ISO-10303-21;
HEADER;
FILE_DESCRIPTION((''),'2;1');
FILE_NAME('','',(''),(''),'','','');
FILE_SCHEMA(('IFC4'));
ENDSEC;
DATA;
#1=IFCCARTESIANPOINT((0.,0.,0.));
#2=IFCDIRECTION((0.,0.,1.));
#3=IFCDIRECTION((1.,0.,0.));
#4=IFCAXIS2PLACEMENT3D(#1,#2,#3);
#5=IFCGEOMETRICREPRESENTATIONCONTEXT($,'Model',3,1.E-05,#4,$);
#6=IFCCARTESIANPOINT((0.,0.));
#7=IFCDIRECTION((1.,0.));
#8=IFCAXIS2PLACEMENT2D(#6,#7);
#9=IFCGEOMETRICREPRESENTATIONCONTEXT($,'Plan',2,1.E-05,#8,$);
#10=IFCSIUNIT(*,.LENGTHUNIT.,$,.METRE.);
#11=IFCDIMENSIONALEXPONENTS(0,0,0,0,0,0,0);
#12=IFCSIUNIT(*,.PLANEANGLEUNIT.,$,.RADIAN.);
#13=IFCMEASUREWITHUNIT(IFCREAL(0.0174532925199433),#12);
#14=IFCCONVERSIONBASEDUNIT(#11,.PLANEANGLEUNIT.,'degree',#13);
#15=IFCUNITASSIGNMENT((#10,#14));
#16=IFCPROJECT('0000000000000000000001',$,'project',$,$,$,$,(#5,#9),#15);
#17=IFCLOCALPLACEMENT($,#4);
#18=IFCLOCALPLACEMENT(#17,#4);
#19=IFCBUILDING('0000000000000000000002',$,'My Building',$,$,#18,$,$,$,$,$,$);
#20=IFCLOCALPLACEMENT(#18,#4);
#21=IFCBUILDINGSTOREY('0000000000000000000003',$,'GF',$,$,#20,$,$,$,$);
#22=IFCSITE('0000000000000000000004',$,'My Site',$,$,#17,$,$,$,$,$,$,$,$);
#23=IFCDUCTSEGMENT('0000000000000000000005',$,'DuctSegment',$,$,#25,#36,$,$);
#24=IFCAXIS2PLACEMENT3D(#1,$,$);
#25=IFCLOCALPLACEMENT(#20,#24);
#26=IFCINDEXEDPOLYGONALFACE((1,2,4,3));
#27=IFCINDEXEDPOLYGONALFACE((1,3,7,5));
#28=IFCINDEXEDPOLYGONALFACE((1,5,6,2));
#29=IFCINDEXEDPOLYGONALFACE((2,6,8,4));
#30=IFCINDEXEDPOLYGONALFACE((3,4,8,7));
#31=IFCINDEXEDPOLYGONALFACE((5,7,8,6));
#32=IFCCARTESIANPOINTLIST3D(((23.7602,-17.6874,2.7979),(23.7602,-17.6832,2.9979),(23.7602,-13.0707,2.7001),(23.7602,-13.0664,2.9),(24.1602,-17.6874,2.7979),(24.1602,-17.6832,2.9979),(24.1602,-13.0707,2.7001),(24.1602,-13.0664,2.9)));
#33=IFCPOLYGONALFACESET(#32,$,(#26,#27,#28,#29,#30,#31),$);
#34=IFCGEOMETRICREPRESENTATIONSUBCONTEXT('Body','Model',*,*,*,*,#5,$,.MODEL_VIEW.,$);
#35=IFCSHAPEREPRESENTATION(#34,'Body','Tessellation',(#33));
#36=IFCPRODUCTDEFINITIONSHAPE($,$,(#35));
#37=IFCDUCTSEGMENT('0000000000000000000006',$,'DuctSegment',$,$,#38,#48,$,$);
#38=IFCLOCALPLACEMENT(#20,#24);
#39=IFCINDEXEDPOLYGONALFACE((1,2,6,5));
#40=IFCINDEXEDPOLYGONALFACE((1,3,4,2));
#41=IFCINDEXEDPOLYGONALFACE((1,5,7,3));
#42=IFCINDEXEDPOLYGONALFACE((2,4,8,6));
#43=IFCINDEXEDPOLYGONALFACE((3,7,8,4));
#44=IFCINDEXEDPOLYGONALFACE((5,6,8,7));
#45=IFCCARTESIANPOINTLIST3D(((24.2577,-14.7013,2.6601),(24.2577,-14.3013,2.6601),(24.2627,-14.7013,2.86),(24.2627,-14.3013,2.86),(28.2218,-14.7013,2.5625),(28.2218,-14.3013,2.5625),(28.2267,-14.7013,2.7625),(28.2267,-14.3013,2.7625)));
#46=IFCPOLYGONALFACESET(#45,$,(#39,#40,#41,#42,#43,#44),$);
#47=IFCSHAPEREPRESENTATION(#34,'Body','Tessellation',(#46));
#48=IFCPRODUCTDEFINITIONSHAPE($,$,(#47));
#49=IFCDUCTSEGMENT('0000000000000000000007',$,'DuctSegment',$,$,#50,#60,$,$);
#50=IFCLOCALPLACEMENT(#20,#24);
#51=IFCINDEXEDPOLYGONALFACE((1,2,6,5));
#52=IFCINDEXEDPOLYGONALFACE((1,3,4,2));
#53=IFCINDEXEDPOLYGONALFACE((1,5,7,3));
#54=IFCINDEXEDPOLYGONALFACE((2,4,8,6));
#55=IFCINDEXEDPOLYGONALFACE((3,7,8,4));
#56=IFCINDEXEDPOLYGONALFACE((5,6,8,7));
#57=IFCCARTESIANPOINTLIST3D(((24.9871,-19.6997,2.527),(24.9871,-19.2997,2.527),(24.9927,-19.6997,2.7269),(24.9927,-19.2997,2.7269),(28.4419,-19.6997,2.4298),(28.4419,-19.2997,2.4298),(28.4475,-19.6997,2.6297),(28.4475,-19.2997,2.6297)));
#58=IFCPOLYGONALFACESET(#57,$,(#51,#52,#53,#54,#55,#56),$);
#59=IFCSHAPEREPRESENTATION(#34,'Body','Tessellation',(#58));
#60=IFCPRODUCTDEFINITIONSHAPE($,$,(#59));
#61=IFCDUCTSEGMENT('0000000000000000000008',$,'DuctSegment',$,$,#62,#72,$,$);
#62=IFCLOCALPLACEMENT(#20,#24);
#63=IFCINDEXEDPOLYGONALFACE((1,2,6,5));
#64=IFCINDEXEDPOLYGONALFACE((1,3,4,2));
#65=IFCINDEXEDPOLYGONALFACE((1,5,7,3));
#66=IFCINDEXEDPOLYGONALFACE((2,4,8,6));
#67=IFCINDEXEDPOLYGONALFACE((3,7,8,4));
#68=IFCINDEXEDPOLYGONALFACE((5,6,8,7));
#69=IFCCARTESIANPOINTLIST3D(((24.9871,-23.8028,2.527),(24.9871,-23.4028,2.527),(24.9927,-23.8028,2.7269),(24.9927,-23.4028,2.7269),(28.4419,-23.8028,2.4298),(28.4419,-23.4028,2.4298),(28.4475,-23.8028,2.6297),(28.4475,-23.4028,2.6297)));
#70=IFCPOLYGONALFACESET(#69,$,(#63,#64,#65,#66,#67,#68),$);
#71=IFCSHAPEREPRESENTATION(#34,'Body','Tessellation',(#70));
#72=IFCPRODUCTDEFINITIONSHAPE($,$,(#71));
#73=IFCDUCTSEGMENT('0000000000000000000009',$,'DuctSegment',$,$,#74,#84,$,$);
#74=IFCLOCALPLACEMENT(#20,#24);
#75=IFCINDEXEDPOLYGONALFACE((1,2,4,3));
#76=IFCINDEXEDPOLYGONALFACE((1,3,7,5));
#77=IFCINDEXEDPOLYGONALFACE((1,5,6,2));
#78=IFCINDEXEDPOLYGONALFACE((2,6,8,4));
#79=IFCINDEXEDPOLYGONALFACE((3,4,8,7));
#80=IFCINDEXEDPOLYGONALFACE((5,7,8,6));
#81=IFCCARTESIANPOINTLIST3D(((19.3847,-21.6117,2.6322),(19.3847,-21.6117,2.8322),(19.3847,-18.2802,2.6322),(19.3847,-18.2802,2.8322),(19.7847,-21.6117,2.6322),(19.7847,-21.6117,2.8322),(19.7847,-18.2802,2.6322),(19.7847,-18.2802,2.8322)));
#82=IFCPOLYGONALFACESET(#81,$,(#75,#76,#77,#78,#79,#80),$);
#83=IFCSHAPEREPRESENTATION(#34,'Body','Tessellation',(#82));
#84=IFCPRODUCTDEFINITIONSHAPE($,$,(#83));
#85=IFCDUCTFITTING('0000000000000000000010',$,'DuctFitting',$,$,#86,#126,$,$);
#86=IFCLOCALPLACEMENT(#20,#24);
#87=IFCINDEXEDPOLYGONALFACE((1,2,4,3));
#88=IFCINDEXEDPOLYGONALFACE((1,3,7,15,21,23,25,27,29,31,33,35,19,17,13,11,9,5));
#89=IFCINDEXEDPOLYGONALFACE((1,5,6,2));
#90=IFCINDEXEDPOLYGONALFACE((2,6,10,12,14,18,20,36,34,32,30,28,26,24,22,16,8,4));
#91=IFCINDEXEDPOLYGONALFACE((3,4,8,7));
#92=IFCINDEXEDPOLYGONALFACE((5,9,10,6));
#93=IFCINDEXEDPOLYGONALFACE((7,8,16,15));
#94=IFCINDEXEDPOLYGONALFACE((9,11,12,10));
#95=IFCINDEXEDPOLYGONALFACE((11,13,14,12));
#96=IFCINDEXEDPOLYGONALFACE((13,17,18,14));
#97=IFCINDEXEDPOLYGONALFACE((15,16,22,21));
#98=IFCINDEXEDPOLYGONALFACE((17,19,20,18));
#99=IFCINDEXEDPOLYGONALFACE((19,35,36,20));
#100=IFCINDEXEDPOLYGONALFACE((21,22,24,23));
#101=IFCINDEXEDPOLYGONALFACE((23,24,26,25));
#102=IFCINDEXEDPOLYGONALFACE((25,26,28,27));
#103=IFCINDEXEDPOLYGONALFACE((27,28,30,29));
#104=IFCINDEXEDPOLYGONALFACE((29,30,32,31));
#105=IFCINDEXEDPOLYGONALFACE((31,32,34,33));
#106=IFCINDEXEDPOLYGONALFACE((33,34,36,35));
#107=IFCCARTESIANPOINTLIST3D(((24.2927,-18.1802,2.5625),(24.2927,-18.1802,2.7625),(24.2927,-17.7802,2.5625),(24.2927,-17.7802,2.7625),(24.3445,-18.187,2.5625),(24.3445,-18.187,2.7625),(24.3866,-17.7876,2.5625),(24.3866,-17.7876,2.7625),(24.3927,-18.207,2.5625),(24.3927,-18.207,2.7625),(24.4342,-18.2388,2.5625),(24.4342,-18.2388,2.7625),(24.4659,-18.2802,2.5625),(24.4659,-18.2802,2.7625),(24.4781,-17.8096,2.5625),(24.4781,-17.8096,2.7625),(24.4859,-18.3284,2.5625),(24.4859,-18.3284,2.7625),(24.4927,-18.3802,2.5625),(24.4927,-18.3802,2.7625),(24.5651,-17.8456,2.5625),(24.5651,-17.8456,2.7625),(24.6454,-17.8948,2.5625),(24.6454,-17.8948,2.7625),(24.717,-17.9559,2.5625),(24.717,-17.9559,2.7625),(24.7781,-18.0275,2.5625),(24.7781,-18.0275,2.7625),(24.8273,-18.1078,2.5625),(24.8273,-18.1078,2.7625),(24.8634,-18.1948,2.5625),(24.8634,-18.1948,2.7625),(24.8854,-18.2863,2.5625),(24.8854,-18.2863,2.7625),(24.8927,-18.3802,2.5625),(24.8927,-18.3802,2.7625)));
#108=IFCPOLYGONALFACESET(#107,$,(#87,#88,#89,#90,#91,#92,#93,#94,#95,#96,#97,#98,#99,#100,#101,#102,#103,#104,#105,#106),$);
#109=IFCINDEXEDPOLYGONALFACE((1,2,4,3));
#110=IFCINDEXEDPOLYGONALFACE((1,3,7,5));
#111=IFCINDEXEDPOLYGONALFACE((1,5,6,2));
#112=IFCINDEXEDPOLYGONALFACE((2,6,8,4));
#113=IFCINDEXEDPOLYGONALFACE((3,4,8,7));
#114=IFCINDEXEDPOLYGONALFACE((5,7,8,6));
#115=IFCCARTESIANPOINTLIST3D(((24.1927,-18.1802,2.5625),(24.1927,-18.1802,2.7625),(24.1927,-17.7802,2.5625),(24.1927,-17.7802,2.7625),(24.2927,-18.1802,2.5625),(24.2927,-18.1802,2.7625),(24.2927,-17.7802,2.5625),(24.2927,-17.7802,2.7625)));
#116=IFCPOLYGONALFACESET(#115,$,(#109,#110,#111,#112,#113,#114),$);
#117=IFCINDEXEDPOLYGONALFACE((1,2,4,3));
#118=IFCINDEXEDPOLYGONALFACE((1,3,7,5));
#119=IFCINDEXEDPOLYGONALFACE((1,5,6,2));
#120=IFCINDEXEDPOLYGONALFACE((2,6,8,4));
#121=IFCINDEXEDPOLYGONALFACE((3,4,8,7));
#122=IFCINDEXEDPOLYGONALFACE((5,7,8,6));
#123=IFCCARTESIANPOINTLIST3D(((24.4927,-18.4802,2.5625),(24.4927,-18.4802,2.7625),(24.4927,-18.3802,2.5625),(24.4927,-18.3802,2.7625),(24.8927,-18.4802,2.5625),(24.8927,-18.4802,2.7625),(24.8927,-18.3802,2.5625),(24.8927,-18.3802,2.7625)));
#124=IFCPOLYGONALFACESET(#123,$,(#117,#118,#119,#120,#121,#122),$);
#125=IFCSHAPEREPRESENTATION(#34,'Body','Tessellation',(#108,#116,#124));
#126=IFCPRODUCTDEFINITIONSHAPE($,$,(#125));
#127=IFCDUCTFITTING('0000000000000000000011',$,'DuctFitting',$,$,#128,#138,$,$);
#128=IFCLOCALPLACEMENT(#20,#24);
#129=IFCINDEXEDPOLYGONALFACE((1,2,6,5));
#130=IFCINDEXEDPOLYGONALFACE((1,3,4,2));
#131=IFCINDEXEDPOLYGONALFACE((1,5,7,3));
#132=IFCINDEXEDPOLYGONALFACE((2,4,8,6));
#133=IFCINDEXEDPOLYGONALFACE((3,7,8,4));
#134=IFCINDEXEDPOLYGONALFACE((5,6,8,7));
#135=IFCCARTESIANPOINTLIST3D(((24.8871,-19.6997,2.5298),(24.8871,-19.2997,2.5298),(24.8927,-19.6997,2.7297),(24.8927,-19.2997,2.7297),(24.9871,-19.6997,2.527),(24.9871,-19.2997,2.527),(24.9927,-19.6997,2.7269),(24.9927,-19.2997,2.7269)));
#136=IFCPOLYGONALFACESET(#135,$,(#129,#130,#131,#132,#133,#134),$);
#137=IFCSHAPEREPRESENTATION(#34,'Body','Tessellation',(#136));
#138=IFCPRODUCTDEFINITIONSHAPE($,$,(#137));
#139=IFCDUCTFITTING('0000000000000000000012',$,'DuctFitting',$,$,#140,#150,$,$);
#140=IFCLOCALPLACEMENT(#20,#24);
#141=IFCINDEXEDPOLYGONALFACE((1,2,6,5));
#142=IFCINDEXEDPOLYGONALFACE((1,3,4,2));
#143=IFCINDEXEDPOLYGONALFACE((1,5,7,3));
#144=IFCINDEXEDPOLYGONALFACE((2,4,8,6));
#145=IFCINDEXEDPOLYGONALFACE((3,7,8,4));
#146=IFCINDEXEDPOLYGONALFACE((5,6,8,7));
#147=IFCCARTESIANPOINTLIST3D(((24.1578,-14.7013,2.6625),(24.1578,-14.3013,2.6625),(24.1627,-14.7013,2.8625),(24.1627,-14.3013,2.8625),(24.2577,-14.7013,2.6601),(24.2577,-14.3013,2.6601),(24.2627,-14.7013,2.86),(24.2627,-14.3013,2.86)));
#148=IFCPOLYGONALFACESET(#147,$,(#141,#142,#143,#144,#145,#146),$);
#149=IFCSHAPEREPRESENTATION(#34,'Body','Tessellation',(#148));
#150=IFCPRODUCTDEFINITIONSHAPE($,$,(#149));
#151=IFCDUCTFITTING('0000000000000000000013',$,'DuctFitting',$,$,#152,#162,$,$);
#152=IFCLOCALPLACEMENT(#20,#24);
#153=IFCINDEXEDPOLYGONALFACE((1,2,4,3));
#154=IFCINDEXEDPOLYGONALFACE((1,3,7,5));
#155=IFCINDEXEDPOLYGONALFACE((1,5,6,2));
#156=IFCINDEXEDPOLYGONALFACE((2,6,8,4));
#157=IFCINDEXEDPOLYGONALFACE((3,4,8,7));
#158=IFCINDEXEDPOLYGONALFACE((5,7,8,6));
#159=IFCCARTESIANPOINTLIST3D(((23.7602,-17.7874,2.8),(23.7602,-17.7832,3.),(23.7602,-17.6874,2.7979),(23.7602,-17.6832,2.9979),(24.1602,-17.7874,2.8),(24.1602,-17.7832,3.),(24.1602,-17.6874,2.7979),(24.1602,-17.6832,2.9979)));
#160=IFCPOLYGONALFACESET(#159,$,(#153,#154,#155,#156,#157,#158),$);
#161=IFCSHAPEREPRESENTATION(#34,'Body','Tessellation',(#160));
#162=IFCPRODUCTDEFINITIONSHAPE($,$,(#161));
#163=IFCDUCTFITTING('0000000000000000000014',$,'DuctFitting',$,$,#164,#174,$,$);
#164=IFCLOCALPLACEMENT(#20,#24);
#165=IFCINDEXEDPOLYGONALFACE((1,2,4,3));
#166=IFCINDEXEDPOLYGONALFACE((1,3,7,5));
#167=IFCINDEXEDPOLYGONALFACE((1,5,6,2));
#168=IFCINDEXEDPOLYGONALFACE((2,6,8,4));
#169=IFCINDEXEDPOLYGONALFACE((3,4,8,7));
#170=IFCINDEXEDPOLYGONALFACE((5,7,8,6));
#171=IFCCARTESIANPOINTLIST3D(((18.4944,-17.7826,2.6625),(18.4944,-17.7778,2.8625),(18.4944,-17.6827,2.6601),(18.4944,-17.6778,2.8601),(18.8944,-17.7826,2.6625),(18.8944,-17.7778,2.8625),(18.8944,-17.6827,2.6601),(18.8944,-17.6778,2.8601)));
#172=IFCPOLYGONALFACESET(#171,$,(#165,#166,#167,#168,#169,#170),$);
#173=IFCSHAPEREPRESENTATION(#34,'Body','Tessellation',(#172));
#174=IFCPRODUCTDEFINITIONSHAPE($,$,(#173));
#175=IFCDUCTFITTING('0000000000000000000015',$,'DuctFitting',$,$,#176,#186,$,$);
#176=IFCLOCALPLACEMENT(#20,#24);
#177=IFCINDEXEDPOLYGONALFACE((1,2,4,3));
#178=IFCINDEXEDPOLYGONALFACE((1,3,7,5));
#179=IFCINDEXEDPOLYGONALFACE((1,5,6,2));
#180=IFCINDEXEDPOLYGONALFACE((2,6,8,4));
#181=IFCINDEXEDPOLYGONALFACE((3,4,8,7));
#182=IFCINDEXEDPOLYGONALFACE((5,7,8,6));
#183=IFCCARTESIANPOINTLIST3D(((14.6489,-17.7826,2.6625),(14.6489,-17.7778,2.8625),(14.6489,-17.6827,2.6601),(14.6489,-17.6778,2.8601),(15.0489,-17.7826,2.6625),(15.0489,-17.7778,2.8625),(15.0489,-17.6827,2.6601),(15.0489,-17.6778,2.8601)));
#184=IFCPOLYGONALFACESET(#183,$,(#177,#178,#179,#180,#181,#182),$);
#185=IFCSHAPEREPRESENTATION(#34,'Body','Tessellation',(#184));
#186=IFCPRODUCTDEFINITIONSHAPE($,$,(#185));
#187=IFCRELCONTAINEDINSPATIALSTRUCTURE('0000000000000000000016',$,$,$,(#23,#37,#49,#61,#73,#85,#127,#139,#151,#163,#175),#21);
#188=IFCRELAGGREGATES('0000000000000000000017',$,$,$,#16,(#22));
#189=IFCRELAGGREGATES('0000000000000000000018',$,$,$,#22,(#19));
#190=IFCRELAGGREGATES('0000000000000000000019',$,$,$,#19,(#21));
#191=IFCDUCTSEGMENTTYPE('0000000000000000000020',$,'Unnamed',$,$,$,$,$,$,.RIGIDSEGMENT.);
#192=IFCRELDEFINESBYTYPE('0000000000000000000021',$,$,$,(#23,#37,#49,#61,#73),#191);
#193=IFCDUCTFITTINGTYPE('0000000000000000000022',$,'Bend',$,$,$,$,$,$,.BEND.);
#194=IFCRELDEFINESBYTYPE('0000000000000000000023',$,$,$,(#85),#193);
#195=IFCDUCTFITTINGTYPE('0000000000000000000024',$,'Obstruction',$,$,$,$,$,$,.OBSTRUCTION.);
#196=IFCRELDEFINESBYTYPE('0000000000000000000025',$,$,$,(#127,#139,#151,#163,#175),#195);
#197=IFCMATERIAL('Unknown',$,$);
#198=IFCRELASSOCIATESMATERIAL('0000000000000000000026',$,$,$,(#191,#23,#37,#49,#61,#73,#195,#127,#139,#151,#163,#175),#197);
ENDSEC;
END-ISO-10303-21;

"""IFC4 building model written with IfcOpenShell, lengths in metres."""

from ifc_helpers import new_model, entity, si_unit, converted_unit, frame, origin_with_axes, origin_2d_with_axis, place, context, subcontext, project, spatial, line, arc, indexed_curve, rectangle, outline, extrude, source, transform, mapped, material, material_profile, profile_set, profile_usage, type_object, type_shapes, element, save


model = new_model("IFC4")

# Units and contexts
model_context = context("Model", 3, precision=1e-05, world=origin_with_axes())
plan_context = context("Plan", 2, precision=1e-05, world=origin_2d_with_axis())
body_context_1 = subcontext(model_context, "Body", "Model", "MODEL_VIEW")
ifc_project = project(units=[si_unit("LENGTHUNIT", "METRE"), converted_unit("PLANEANGLEUNIT", "degree", entity("IfcReal", 0.0174532925199433), si_unit("PLANEANGLEUNIT", "RADIAN"), dimensions=[0, 0, 0, 0, 0, 0, 0])], contexts=[model_context, plan_context])

# Site, building, storey
site_placement = place(None, origin_with_axes())
site = spatial("IfcSite", under=ifc_project, at=site_placement, Name="My Site")
building_placement = place(site_placement, origin_with_axes())
building = spatial("IfcBuilding", under=site, at=building_placement, Name="My Building")
storey_placement = place(building_placement, origin_with_axes())
storey = spatial("IfcBuildingStorey", under=building, at=storey_placement, Name="GF")

# Shared definitions
ifc_material = material(Name="Unknown")

# Duct segments
ifc_material_profile_1 = material_profile(ifc_material, rectangle(XDim=0.4, YDim=0.2))
ifc_profile_set_1 = profile_set([ifc_material_profile_1])
duct_segment_type = type_object("IfcDuctSegmentType", Name="Unnamed", PredefinedType="RIGIDSEGMENT", material=ifc_profile_set_1)
ifc_profile_usage_1 = profile_usage(ifc_profile_set_1, cardinal=5)
duct_segment_1_placement = place(storey_placement, frame((23.9602, -17.6853, 2.8979), z_axis=(0.0, 0.999775, -0.021196), x_axis=(-1.0, 0.0, 0.0)))
element("IfcDuctSegment", 1, at=duct_segment_1_placement, inside=storey, type_object=duct_segment_type, material=ifc_profile_usage_1, Name="DuctSegment", context=body_context_1, shape_type="SweptSolid", body=[
    extrude(rectangle(XDim=0.4, YDim=0.2), origin_with_axes(), (0.0, 0.0, 1.0), 4.6178),
])
ifc_profile_usage_2 = profile_usage(ifc_profile_set_1, cardinal=5)
duct_segment_2_placement = place(storey_placement, frame((24.2602, -14.5013, 2.7601), z_axis=(0.999697, 0.0, -0.024598), x_axis=(0.0, 1.0, 0.0)))
element("IfcDuctSegment", 2, at=duct_segment_2_placement, inside=storey, type_object=duct_segment_type, material=ifc_profile_usage_2, Name="DuctSegment", context=body_context_1, shape_type="SweptSolid", body=[
    extrude(rectangle(XDim=0.4, YDim=0.2), origin_with_axes(), (0.0, 0.0, 1.0), 3.9652),
])
ifc_profile_usage_3 = profile_usage(ifc_profile_set_1, cardinal=5)
duct_segment_3_placement = place(storey_placement, frame((24.9899, -19.4997, 2.6269), z_axis=(0.999605, 0.0, -0.02812), x_axis=(0.0, 1.0, 0.0)))
element("IfcDuctSegment", 3, at=duct_segment_3_placement, inside=storey, type_object=duct_segment_type, material=ifc_profile_usage_3, Name="DuctSegment", context=body_context_1, shape_type="SweptSolid", body=[
    extrude(rectangle(XDim=0.4, YDim=0.2), origin_with_axes(), (0.0, 0.0, 1.0), 3.4562),
])
ifc_profile_usage_4 = profile_usage(ifc_profile_set_1, cardinal=5)
duct_segment_4_placement = place(storey_placement, frame((24.9899, -23.6028, 2.6269), z_axis=(0.999605, 0.0, -0.02812), x_axis=(0.0, 1.0, 0.0)))
element("IfcDuctSegment", 4, at=duct_segment_4_placement, inside=storey, type_object=duct_segment_type, material=ifc_profile_usage_4, Name="DuctSegment", context=body_context_1, shape_type="SweptSolid", body=[
    extrude(rectangle(XDim=0.4, YDim=0.2), origin_with_axes(), (0.0, 0.0, 1.0), 3.4562),
])
ifc_profile_usage_5 = profile_usage(ifc_profile_set_1, cardinal=5)
duct_segment_5_placement = place(storey_placement, frame((19.5847, -18.2802, 2.7322), z_axis=(0.0, -1.0, 0.0), x_axis=(1.0, 0.0, 0.0)))
element("IfcDuctSegment", 5, at=duct_segment_5_placement, inside=storey, type_object=duct_segment_type, material=ifc_profile_usage_5, Name="DuctSegment", context=body_context_1, shape_type="SweptSolid", body=[
    extrude(rectangle(XDim=0.4, YDim=0.2), origin_with_axes(), (0.0, 0.0, 1.0), 3.3315),
])

# Duct fittings
duct_fitting_type_1 = type_object("IfcDuctFittingType", Name="Bend", PredefinedType="BEND")
shared_shape_1 = source(origin_with_axes(), body_context_1, "Body", "SweptSolid", [
    extrude(outline(indexed_curve([(0.2, 0.0), (0.2586, -0.1414), (0.4, -0.2), (0.4, -0.6), (-0.0243, -0.4243), (-0.2, 0.0)], segments=[arc(1, 2, 3), line(3, 4), arc(4, 5, 6), line(6, 1)])), frame((0.0, -0.1, -0.1), z_axis=(0.0, -1.0, 0.0), x_axis=(1.0, 0.0, 0.0)), (0.0, 0.0, -1.0), 0.2),
    extrude(rectangle(XDim=0.4, YDim=0.2), origin_with_axes(), (0.0, 0.0, -1.0), 0.1),
    extrude(rectangle(XDim=0.4, YDim=0.2), frame((0.4, 0.0, -0.5), z_axis=(1.0, 0.0, 0.0), x_axis=(0.0, 0.0, 1.0)), (0.0, 0.0, 1.0), 0.1),
])
type_shapes(duct_fitting_type_1, [shared_shape_1])
duct_fitting_1_placement = place(storey_placement, frame((24.1927, -17.9802, 2.6625), z_axis=(-1.0, 0.0, 0.0), x_axis=(0.0, -1.0, 0.0)))
element("IfcDuctFitting", 6, at=duct_fitting_1_placement, inside=storey, type_object=duct_fitting_type_1, Name="DuctFitting", context=body_context_1, shape_type="MappedRepresentation", body=[
    mapped(shared_shape_1, transform((0.0, 0.0, 0.0), x_axis=(1.0, 0.0, 0.0), y_axis=(0.0, 1.0, 0.0), z_axis=(0.0, 0.0, 1.0), scale=1.0)),
])
ifc_material_profile_2 = material_profile(ifc_material, rectangle(XDim=0.4, YDim=0.2))
ifc_profile_set_2 = profile_set([ifc_material_profile_2])
ifc_profile_usage_6 = profile_usage(ifc_profile_set_2, cardinal=5)
duct_fitting_type_2 = type_object("IfcDuctFittingType", Name="Obstruction", PredefinedType="OBSTRUCTION", material=ifc_profile_set_2)
duct_fitting_2_placement = place(storey_placement, frame((24.8899, -19.4997, 2.6297), z_axis=(0.999605, 0.0, -0.02812), x_axis=(0.0, 1.0, 0.0)))
element("IfcDuctFitting", 7, at=duct_fitting_2_placement, inside=storey, type_object=duct_fitting_type_2, material=ifc_profile_usage_6, Name="DuctFitting", context=body_context_1, shape_type="SweptSolid", body=[
    extrude(rectangle(XDim=0.4, YDim=0.2), origin_with_axes(), (0.0, 0.0, 1.0), 0.1),
])
ifc_profile_usage_7 = profile_usage(ifc_profile_set_2, cardinal=5)
duct_fitting_3_placement = place(storey_placement, frame((24.1602, -14.5013, 2.7625), z_axis=(0.999697, 0.0, -0.024598), x_axis=(0.0, 1.0, 0.0)))
element("IfcDuctFitting", 8, at=duct_fitting_3_placement, inside=storey, type_object=duct_fitting_type_2, material=ifc_profile_usage_7, Name="DuctFitting", context=body_context_1, shape_type="SweptSolid", body=[
    extrude(rectangle(XDim=0.4, YDim=0.2), origin_with_axes(), (0.0, 0.0, 1.0), 0.1),
])
ifc_profile_usage_8 = profile_usage(ifc_profile_set_2, cardinal=5)
duct_fitting_4_placement = place(storey_placement, frame((23.9602, -17.7853, 2.9), z_axis=(0.0, 0.999775, -0.021196), x_axis=(-1.0, 0.0, 0.0)))
element("IfcDuctFitting", 9, at=duct_fitting_4_placement, inside=storey, type_object=duct_fitting_type_2, material=ifc_profile_usage_8, Name="DuctFitting", context=body_context_1, shape_type="SweptSolid", body=[
    extrude(rectangle(XDim=0.4, YDim=0.2), origin_with_axes(), (0.0, 0.0, 1.0), 0.1),
])
ifc_profile_usage_9 = profile_usage(ifc_profile_set_2, cardinal=5)
duct_fitting_5_placement = place(storey_placement, frame((18.6944, -17.7802, 2.7625), z_axis=(0.0, 0.999706, -0.02423), x_axis=(-1.0, 0.0, 0.0)))
element("IfcDuctFitting", 10, at=duct_fitting_5_placement, inside=storey, type_object=duct_fitting_type_2, material=ifc_profile_usage_9, Name="DuctFitting", context=body_context_1, shape_type="SweptSolid", body=[
    extrude(rectangle(XDim=0.4, YDim=0.2), origin_with_axes(), (0.0, 0.0, 1.0), 0.1),
])
ifc_profile_usage_10 = profile_usage(ifc_profile_set_2, cardinal=5)
duct_fitting_6_placement = place(storey_placement, frame((14.8489, -17.7802, 2.7625), z_axis=(0.0, 0.999706, -0.02423), x_axis=(-1.0, 0.0, 0.0)))
element("IfcDuctFitting", 11, at=duct_fitting_6_placement, inside=storey, type_object=duct_fitting_type_2, material=ifc_profile_usage_10, Name="DuctFitting", context=body_context_1, shape_type="SweptSolid", body=[
    extrude(rectangle(XDim=0.4, YDim=0.2), origin_with_axes(), (0.0, 0.0, 1.0), 0.1),
])

save(model, "model.ifc")
